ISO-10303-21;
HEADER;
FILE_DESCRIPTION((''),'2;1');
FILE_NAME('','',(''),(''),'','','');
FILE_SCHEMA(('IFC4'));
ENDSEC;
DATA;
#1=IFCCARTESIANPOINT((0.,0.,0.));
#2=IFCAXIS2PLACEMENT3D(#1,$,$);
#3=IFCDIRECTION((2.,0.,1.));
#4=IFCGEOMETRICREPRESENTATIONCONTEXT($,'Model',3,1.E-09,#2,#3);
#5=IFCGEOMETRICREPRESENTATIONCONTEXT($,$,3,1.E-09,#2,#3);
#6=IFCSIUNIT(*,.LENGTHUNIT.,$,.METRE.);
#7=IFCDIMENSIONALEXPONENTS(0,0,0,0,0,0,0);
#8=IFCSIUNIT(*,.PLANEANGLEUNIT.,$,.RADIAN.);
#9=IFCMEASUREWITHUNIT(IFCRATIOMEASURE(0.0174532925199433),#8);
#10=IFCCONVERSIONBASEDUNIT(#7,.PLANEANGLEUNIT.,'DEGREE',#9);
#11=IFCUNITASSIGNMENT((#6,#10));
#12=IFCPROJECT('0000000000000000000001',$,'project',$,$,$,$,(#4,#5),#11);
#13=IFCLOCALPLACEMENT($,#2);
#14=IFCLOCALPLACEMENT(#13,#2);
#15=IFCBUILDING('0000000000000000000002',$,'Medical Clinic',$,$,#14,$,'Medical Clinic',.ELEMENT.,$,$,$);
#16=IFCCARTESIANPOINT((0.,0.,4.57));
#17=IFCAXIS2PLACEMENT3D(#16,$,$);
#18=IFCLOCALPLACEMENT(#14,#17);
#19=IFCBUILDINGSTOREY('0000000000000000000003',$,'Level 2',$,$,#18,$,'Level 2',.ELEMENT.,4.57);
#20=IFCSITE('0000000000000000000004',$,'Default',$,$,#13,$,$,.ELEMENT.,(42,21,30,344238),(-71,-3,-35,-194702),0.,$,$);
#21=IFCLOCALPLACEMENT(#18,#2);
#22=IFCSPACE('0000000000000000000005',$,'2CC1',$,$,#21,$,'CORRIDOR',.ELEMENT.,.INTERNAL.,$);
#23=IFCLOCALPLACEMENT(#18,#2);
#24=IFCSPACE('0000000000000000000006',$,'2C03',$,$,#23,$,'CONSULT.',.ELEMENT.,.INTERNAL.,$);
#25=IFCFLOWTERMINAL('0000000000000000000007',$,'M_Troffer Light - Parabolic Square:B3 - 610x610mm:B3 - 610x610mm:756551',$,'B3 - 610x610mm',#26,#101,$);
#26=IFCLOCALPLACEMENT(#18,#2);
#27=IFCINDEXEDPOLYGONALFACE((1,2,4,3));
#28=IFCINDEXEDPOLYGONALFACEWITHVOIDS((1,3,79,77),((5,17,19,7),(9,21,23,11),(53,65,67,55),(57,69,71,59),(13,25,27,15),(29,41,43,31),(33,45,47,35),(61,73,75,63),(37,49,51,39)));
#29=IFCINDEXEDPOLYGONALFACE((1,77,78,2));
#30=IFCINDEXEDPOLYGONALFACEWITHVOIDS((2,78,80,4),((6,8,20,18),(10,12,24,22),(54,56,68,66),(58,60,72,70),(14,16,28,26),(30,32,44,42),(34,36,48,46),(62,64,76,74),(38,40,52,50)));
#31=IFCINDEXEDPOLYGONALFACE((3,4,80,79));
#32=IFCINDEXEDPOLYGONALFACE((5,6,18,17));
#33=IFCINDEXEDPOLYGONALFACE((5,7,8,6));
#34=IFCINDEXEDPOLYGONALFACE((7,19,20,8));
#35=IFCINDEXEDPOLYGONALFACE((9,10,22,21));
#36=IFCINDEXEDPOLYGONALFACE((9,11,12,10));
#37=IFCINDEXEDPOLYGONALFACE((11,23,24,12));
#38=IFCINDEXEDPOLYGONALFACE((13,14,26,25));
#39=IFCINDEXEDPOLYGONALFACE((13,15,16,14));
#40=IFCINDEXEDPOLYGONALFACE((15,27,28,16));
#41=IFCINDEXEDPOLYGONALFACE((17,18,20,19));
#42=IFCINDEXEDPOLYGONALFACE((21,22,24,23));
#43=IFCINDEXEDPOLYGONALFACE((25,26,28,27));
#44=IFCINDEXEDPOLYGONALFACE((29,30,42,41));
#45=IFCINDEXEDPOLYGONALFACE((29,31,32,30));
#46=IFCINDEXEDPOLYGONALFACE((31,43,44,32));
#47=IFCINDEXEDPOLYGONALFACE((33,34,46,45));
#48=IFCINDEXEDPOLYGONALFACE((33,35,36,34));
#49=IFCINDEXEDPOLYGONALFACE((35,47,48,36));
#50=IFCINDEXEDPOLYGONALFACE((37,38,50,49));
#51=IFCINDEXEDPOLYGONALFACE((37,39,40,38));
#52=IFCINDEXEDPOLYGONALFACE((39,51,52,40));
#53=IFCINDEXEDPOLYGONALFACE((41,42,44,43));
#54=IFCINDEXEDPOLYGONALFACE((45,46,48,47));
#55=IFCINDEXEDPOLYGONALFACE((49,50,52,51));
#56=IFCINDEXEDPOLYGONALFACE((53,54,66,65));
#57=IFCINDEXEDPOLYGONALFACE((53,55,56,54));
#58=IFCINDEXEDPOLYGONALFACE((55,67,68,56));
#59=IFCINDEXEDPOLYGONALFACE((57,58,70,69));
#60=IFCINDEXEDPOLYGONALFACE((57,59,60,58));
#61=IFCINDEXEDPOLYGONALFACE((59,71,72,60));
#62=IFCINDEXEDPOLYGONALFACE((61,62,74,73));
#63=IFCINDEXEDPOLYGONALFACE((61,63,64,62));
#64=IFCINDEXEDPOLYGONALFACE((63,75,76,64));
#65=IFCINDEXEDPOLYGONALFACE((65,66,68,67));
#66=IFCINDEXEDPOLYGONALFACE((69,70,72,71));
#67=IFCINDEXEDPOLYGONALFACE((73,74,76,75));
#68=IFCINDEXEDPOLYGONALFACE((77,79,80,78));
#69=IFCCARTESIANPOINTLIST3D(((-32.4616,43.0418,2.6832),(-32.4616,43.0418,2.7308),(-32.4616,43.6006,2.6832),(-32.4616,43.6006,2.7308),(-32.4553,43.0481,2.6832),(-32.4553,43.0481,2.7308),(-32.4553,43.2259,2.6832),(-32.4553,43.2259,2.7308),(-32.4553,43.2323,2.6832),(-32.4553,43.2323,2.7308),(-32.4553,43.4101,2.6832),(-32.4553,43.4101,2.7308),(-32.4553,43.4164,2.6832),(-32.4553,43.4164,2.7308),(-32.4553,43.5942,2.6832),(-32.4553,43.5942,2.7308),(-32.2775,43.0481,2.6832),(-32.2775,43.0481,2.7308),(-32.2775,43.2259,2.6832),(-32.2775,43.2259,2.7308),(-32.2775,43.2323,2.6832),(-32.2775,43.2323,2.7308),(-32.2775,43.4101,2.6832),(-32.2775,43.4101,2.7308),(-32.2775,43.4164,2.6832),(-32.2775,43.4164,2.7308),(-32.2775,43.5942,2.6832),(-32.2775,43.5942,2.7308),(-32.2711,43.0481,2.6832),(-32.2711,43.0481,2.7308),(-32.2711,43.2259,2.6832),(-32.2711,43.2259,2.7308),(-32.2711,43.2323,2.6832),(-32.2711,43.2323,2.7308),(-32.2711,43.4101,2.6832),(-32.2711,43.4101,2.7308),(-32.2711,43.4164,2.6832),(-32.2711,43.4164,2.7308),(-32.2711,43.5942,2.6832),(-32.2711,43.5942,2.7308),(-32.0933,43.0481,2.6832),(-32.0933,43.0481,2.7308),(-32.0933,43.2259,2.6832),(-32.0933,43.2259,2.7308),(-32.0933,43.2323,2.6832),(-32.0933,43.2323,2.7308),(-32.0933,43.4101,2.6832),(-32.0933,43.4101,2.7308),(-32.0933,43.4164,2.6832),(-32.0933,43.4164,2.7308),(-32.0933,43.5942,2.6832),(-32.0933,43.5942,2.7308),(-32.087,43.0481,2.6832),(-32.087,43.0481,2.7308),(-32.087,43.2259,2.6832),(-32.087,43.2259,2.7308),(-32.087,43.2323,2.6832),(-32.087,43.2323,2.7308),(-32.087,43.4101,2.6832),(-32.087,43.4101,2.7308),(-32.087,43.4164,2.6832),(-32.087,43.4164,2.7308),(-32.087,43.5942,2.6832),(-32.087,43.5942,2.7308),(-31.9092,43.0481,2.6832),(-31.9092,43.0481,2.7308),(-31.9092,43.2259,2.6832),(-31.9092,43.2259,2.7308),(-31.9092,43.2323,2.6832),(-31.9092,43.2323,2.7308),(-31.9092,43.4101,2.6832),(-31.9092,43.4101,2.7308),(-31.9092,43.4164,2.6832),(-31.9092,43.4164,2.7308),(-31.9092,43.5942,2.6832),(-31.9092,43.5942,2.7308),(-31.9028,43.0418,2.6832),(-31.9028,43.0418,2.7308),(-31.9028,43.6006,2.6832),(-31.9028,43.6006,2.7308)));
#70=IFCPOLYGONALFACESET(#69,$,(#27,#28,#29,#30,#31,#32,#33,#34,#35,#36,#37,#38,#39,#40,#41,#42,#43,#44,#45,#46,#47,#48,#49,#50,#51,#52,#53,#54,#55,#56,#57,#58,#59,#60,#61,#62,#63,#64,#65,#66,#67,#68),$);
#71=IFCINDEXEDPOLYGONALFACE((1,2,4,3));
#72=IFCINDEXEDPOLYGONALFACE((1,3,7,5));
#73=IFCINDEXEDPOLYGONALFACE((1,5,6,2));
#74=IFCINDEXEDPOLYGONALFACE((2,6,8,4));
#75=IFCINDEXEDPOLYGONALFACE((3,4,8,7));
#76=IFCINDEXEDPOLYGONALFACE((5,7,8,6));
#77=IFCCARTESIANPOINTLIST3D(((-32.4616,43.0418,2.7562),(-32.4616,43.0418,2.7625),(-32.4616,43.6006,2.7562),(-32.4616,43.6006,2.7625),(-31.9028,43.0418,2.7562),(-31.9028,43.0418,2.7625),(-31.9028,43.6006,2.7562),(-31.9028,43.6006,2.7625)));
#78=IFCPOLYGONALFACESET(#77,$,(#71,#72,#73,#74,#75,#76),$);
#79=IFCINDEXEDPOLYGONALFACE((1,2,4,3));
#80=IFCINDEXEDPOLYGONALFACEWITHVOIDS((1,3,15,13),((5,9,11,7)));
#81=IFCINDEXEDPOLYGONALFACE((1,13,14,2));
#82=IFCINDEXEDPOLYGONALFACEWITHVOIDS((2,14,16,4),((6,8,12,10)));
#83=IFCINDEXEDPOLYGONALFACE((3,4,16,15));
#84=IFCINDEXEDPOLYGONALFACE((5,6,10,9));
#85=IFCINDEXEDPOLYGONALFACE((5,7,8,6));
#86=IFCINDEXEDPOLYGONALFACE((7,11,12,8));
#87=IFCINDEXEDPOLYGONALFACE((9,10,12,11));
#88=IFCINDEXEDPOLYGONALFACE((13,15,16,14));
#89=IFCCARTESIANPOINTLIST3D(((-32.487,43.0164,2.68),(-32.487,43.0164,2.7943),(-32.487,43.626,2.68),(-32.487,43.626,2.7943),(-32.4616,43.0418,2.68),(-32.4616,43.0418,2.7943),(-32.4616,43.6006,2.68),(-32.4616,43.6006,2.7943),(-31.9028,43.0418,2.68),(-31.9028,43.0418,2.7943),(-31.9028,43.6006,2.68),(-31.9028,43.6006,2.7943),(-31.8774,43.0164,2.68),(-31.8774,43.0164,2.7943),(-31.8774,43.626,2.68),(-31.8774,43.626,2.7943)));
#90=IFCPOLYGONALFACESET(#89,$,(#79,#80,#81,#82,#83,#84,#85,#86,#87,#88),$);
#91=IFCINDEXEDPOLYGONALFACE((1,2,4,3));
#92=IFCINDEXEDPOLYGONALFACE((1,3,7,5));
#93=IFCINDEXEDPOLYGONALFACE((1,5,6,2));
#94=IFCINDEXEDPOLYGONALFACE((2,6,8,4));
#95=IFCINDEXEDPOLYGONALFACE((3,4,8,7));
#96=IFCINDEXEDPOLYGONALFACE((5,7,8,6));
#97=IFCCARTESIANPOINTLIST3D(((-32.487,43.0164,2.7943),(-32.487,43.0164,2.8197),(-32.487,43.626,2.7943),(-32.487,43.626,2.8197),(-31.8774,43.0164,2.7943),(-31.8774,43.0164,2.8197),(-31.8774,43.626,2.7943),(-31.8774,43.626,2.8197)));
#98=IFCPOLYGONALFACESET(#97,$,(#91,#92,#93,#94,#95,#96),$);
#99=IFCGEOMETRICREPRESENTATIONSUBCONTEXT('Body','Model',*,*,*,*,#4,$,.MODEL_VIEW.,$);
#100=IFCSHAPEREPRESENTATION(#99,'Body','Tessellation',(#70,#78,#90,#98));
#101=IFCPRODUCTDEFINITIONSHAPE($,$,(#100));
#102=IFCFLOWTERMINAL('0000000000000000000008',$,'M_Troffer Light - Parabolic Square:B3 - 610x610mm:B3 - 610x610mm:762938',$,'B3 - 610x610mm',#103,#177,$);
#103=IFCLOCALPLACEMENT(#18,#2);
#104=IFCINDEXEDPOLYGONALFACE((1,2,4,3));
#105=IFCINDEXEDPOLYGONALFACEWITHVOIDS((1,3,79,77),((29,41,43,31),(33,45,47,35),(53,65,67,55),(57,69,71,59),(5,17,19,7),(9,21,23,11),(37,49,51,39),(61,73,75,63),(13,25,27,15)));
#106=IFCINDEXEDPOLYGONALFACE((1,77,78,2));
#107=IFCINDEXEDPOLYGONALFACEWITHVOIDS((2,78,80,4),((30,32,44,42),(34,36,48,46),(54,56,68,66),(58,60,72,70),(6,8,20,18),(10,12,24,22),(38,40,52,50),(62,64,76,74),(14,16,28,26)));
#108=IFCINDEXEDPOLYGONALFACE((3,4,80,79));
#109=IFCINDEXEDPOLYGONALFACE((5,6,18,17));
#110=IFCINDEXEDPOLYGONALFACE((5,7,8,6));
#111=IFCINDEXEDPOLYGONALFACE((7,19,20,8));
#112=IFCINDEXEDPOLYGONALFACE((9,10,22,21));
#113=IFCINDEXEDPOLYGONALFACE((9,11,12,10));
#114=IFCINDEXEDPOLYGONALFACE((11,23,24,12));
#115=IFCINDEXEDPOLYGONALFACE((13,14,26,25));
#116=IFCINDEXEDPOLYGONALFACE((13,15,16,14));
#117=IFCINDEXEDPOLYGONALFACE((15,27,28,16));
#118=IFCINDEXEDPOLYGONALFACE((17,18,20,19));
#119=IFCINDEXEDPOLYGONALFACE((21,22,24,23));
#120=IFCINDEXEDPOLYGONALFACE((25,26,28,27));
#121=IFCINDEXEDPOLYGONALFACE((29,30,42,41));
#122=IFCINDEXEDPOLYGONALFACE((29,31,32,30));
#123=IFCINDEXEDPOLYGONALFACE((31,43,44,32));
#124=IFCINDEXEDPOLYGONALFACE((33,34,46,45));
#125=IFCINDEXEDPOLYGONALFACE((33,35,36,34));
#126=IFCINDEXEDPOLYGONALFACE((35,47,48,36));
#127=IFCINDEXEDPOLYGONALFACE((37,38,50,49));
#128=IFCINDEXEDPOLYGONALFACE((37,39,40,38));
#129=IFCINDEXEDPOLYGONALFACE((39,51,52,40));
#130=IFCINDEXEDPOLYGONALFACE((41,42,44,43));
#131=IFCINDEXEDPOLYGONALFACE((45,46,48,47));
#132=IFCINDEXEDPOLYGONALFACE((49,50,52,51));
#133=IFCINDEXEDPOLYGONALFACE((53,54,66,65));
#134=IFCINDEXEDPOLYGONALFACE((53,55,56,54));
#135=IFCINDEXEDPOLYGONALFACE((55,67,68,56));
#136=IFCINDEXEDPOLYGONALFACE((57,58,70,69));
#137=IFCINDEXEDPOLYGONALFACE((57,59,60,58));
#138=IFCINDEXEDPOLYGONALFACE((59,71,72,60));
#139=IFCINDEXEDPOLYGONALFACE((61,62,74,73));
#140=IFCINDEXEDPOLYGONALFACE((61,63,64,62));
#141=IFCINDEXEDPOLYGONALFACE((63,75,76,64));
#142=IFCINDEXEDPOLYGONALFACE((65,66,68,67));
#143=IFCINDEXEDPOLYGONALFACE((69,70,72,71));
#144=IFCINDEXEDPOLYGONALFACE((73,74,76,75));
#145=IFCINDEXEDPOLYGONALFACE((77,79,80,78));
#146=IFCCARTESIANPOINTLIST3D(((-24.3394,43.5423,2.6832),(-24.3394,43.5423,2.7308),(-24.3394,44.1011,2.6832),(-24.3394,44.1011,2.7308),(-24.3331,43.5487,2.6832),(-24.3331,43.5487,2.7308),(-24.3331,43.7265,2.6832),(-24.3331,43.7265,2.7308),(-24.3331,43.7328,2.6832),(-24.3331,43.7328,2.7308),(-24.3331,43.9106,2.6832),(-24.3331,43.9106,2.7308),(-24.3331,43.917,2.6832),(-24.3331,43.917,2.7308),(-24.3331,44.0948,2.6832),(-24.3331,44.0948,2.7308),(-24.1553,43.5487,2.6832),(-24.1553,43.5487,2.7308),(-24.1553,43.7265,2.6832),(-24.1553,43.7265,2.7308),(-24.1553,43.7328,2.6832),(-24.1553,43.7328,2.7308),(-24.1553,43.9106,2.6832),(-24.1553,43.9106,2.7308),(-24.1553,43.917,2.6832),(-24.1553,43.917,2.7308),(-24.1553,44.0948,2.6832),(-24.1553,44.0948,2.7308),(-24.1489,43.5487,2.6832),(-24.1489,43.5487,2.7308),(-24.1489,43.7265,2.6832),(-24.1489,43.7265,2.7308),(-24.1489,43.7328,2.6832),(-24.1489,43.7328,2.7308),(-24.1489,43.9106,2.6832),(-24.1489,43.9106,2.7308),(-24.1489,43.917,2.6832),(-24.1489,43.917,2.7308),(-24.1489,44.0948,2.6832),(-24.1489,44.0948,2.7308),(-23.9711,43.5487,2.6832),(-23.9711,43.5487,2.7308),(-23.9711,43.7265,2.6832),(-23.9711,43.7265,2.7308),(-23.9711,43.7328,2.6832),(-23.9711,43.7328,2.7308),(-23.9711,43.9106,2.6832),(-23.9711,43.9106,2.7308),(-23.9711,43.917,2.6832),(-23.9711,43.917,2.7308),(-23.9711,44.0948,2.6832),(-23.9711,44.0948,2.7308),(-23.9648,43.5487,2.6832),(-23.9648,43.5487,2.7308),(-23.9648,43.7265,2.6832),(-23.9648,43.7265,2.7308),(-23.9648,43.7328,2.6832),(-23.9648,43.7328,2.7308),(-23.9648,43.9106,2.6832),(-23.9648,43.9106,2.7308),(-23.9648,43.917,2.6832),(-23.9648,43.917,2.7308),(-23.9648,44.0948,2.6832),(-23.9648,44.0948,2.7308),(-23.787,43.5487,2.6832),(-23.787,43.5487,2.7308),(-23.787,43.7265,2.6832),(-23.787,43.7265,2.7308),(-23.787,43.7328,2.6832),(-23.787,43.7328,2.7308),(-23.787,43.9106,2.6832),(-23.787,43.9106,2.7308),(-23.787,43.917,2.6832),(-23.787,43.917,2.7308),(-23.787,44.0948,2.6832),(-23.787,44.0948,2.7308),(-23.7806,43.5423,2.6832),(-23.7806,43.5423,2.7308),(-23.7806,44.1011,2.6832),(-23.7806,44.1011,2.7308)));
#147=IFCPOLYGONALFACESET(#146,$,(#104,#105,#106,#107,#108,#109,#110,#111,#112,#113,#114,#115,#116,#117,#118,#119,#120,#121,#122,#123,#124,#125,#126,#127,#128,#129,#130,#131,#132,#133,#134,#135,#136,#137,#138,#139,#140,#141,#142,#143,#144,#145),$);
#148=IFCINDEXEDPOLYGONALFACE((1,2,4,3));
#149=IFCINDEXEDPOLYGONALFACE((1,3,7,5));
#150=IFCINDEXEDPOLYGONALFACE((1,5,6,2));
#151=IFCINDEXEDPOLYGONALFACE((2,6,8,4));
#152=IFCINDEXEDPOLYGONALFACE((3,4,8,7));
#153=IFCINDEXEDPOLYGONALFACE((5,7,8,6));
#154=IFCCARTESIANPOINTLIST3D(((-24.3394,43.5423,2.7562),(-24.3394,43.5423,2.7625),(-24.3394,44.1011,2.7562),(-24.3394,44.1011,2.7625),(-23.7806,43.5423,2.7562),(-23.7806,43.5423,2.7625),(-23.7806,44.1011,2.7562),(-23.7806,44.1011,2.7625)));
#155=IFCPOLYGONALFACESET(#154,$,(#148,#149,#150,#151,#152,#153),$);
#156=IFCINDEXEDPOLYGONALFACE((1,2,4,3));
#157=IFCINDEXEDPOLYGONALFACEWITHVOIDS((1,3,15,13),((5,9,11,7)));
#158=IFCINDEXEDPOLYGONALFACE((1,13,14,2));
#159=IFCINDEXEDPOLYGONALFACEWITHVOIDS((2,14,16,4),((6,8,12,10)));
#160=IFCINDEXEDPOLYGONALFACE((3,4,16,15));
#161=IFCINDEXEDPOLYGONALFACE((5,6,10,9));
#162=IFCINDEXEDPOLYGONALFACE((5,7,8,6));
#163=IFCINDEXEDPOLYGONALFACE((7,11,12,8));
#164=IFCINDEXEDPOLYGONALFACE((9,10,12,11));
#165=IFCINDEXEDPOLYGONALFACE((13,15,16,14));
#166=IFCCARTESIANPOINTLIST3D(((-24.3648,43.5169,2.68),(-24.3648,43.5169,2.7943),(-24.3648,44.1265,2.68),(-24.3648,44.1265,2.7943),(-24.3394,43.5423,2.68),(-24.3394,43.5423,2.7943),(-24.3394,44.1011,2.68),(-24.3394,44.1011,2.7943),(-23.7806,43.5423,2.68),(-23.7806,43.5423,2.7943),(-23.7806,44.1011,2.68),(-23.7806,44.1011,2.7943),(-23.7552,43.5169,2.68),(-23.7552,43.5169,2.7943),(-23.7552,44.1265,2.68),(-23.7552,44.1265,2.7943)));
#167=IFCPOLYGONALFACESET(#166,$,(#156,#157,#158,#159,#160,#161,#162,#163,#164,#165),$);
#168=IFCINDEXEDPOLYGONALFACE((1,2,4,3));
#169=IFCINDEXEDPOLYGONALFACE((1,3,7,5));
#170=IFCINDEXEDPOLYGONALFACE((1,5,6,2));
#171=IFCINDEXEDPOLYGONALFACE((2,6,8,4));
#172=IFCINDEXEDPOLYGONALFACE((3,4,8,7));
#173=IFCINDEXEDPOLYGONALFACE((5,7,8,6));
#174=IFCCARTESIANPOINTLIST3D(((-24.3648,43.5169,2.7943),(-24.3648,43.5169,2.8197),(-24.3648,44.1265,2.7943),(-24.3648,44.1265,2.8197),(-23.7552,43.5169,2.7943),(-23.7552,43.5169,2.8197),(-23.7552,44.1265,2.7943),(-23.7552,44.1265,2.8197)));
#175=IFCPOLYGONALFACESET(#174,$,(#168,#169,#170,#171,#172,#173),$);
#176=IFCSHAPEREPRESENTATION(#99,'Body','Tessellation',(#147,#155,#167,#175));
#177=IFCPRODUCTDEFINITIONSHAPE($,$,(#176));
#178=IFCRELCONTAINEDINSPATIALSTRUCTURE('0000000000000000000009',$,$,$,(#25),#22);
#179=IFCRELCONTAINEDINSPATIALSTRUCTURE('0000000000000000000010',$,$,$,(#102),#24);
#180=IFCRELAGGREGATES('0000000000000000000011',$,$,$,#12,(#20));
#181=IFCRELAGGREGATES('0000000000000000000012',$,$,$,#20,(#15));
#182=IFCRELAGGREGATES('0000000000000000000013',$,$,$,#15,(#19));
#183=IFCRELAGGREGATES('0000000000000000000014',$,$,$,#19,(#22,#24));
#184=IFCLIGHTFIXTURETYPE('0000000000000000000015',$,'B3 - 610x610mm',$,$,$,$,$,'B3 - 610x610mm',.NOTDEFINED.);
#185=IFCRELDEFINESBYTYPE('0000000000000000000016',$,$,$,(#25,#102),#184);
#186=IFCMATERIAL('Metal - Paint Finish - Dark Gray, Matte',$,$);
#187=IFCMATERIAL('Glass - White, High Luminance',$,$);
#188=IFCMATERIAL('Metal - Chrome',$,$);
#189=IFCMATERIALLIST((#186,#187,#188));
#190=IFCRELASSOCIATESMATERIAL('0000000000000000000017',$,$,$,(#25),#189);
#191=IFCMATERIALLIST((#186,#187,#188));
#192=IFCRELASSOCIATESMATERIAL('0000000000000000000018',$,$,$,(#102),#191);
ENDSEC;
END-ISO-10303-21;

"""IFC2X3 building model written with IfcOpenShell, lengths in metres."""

from ifc_helpers import new_model, entity, si_unit, converted_unit, direction, frame, origin, origin_2d_with_axis, place, context, subcontext, project, spatial, polyline, rectangle, outline, extrude, source, transform, mapped, material, material_list, type_object, type_shapes, element, save


model = new_model("IFC2X3")

# Units and contexts
model_context = context("Model", 3, precision=1e-09, world=origin(), true_north=direction((2.0, 0.0, 1.0)))
context_of_model = context(None, 3, precision=1e-09, world=origin(), true_north=direction((2.0, 0.0, 1.0)))
body_context = subcontext(model_context, "Body", "Model", "MODEL_VIEW")
ifc_project = project(units=[si_unit("LENGTHUNIT", "METRE"), converted_unit("PLANEANGLEUNIT", "DEGREE", entity("IfcRatioMeasure", 0.0174532925199433), si_unit("PLANEANGLEUNIT", "RADIAN"), dimensions=[0, 0, 0, 0, 0, 0, 0])], contexts=[model_context, context_of_model])

# Site, building, storey, space
site_placement = place(None, origin())
site = spatial("IfcSite", under=ifc_project, at=site_placement, Name="Default", CompositionType="ELEMENT", RefLatitude=(42, 21, 30, 344238), RefLongitude=(-71, -3, -35, -194702), RefElevation=0.0)
building_placement = place(site_placement, origin())
building = spatial("IfcBuilding", under=site, at=building_placement, Name="Medical Clinic", LongName="Medical Clinic", CompositionType="ELEMENT")
storey_placement = place(building_placement, frame((0.0, 0.0, 4.57)))
storey = spatial("IfcBuildingStorey", under=building, at=storey_placement, Name="Level 2", LongName="Level 2", CompositionType="ELEMENT", Elevation=4.57)
space_1_placement = place(storey_placement, origin())
space_1 = spatial("IfcSpace", under=storey, at=space_1_placement, Name="2CC1", LongName="CORRIDOR", CompositionType="ELEMENT", InteriorOrExteriorSpace="INTERNAL")

# Flow terminal
ifc_material_1 = material(Name="Metal - Paint Finish - Dark Gray, Matte")
ifc_material_2 = material(Name="Glass - White, High Luminance")
ifc_material_3 = material(Name="Metal - Chrome")
ifc_material_list_1 = material_list([ifc_material_1, ifc_material_2, ifc_material_3])
light_fixture_type_1 = type_object("IfcLightFixtureType", Name="B3 - 610x610mm", ElementType="B3 - 610x610mm", PredefinedType="NOTDEFINED")
shared_shape_1 = source(origin(), body_context, "Body", "SweptSolid", [
    extrude(outline(polyline([(-0.2794, -0.2794), (0.2794, -0.2794), (0.2794, 0.2794), (-0.2794, 0.2794), (-0.2794, -0.2794)]), holes=[polyline([(-0.0952, 0.0953), (-0.273, 0.0953), (-0.273, 0.2731), (-0.0952, 0.2731), (-0.0952, 0.0953)]), polyline([(0.2731, 0.0953), (0.0953, 0.0953), (0.0953, 0.2731), (0.2731, 0.2731), (0.2731, 0.0953)]), polyline([(-0.0889, 0.2731), (0.0889, 0.2731), (0.0889, 0.0953), (-0.0889, 0.0953), (-0.0889, 0.2731)]), polyline([(0.2731, -0.273), (0.0953, -0.273), (0.0953, -0.0952), (0.2731, -0.0952), (0.2731, -0.273)]), polyline([(0.0889, -0.273), (-0.0889, -0.273), (-0.0889, -0.0952), (0.0889, -0.0952), (0.0889, -0.273)]), polyline([(-0.0952, -0.273), (-0.273, -0.273), (-0.273, -0.0952), (-0.0952, -0.0952), (-0.0952, -0.273)]), polyline([(-0.0952, -0.0889), (-0.273, -0.0889), (-0.273, 0.0889), (-0.0952, 0.0889), (-0.0952, -0.0889)]), polyline([(0.0889, -0.0889), (-0.0889, -0.0889), (-0.0889, 0.0889), (0.0889, 0.0889), (0.0889, -0.0889)]), polyline([(0.2731, -0.0889), (0.0953, -0.0889), (0.0953, 0.0889), (0.2731, 0.0889), (0.2731, -0.0889)])]), frame((0.0, -0.3048, -0.0508), z_axis=(0.0, 0.0, 1.0), x_axis=(-1.0, 0.0, 0.0)), (0.0, 0.0, 1.0), 0.0476),
    extrude(rectangle(XDim=0.5588, YDim=0.5588, at=origin_2d_with_axis()), frame((0.0, -0.3048, -0.0825), z_axis=(0.0, 0.0, 1.0), x_axis=(-1.0, 0.0, 0.0)), (0.0, 0.0, 1.0), 0.0064),
    extrude(outline(polyline([(-0.3048, -0.3048), (0.3048, -0.3048), (0.3048, 0.3048), (-0.3048, 0.3048), (-0.3048, -0.3048)]), holes=[polyline([(0.2794, 0.2794), (0.2794, -0.2794), (-0.2794, -0.2794), (-0.2794, 0.2794), (0.2794, 0.2794)])]), frame((0.0, -0.3048, -0.1143)), (0.0, 0.0, 1.0), 0.1143),
    extrude(rectangle(XDim=0.6096, YDim=0.6096, at=origin_2d_with_axis()), frame((0.0, -0.3048, -0.1397), z_axis=(0.0, 0.0, 1.0), x_axis=(-1.0, 0.0, 0.0)), (0.0, 0.0, 1.0), 0.0254),
])
type_shapes(light_fixture_type_1, [shared_shape_1])
flow_terminal_1_placement = place(space_1_placement, frame((-32.1822, 43.0164, 2.68), z_axis=(0.0, 0.0, -1.0), x_axis=(1.0, 0.0, 0.0)))
element("IfcFlowTerminal", 1, at=flow_terminal_1_placement, inside=space_1, type_object=light_fixture_type_1, material=ifc_material_list_1, Name="M_Troffer Light - Parabolic Square:B3 - 610x610mm:B3 - 610x610mm:756551", ObjectType="B3 - 610x610mm", context=body_context, shape_type="MappedRepresentation", body=[
    mapped(shared_shape_1, transform((0.0, 0.0, 0.0), scale=1.0)),
])

# Shared definitions
space_2_placement = place(storey_placement, origin())
space_2 = spatial("IfcSpace", under=storey, at=space_2_placement, Name="2C03", LongName="CONSULT.", CompositionType="ELEMENT", InteriorOrExteriorSpace="INTERNAL")

# Flow terminal
ifc_material_list_2 = material_list([ifc_material_1, ifc_material_2, ifc_material_3])
flow_terminal_2_placement = place(space_2_placement, frame((-24.06, 43.5169, 2.68), z_axis=(0.0, 0.0, -1.0), x_axis=(1.0, 0.0, 0.0)))
element("IfcFlowTerminal", 2, at=flow_terminal_2_placement, inside=space_2, type_object=light_fixture_type_1, material=ifc_material_list_2, Name="M_Troffer Light - Parabolic Square:B3 - 610x610mm:B3 - 610x610mm:762938", ObjectType="B3 - 610x610mm", context=body_context, shape_type="MappedRepresentation", body=[
    mapped(shared_shape_1, transform((0.0, 0.0, 0.0), scale=1.0)),
])

save(model, "model.ifc")
